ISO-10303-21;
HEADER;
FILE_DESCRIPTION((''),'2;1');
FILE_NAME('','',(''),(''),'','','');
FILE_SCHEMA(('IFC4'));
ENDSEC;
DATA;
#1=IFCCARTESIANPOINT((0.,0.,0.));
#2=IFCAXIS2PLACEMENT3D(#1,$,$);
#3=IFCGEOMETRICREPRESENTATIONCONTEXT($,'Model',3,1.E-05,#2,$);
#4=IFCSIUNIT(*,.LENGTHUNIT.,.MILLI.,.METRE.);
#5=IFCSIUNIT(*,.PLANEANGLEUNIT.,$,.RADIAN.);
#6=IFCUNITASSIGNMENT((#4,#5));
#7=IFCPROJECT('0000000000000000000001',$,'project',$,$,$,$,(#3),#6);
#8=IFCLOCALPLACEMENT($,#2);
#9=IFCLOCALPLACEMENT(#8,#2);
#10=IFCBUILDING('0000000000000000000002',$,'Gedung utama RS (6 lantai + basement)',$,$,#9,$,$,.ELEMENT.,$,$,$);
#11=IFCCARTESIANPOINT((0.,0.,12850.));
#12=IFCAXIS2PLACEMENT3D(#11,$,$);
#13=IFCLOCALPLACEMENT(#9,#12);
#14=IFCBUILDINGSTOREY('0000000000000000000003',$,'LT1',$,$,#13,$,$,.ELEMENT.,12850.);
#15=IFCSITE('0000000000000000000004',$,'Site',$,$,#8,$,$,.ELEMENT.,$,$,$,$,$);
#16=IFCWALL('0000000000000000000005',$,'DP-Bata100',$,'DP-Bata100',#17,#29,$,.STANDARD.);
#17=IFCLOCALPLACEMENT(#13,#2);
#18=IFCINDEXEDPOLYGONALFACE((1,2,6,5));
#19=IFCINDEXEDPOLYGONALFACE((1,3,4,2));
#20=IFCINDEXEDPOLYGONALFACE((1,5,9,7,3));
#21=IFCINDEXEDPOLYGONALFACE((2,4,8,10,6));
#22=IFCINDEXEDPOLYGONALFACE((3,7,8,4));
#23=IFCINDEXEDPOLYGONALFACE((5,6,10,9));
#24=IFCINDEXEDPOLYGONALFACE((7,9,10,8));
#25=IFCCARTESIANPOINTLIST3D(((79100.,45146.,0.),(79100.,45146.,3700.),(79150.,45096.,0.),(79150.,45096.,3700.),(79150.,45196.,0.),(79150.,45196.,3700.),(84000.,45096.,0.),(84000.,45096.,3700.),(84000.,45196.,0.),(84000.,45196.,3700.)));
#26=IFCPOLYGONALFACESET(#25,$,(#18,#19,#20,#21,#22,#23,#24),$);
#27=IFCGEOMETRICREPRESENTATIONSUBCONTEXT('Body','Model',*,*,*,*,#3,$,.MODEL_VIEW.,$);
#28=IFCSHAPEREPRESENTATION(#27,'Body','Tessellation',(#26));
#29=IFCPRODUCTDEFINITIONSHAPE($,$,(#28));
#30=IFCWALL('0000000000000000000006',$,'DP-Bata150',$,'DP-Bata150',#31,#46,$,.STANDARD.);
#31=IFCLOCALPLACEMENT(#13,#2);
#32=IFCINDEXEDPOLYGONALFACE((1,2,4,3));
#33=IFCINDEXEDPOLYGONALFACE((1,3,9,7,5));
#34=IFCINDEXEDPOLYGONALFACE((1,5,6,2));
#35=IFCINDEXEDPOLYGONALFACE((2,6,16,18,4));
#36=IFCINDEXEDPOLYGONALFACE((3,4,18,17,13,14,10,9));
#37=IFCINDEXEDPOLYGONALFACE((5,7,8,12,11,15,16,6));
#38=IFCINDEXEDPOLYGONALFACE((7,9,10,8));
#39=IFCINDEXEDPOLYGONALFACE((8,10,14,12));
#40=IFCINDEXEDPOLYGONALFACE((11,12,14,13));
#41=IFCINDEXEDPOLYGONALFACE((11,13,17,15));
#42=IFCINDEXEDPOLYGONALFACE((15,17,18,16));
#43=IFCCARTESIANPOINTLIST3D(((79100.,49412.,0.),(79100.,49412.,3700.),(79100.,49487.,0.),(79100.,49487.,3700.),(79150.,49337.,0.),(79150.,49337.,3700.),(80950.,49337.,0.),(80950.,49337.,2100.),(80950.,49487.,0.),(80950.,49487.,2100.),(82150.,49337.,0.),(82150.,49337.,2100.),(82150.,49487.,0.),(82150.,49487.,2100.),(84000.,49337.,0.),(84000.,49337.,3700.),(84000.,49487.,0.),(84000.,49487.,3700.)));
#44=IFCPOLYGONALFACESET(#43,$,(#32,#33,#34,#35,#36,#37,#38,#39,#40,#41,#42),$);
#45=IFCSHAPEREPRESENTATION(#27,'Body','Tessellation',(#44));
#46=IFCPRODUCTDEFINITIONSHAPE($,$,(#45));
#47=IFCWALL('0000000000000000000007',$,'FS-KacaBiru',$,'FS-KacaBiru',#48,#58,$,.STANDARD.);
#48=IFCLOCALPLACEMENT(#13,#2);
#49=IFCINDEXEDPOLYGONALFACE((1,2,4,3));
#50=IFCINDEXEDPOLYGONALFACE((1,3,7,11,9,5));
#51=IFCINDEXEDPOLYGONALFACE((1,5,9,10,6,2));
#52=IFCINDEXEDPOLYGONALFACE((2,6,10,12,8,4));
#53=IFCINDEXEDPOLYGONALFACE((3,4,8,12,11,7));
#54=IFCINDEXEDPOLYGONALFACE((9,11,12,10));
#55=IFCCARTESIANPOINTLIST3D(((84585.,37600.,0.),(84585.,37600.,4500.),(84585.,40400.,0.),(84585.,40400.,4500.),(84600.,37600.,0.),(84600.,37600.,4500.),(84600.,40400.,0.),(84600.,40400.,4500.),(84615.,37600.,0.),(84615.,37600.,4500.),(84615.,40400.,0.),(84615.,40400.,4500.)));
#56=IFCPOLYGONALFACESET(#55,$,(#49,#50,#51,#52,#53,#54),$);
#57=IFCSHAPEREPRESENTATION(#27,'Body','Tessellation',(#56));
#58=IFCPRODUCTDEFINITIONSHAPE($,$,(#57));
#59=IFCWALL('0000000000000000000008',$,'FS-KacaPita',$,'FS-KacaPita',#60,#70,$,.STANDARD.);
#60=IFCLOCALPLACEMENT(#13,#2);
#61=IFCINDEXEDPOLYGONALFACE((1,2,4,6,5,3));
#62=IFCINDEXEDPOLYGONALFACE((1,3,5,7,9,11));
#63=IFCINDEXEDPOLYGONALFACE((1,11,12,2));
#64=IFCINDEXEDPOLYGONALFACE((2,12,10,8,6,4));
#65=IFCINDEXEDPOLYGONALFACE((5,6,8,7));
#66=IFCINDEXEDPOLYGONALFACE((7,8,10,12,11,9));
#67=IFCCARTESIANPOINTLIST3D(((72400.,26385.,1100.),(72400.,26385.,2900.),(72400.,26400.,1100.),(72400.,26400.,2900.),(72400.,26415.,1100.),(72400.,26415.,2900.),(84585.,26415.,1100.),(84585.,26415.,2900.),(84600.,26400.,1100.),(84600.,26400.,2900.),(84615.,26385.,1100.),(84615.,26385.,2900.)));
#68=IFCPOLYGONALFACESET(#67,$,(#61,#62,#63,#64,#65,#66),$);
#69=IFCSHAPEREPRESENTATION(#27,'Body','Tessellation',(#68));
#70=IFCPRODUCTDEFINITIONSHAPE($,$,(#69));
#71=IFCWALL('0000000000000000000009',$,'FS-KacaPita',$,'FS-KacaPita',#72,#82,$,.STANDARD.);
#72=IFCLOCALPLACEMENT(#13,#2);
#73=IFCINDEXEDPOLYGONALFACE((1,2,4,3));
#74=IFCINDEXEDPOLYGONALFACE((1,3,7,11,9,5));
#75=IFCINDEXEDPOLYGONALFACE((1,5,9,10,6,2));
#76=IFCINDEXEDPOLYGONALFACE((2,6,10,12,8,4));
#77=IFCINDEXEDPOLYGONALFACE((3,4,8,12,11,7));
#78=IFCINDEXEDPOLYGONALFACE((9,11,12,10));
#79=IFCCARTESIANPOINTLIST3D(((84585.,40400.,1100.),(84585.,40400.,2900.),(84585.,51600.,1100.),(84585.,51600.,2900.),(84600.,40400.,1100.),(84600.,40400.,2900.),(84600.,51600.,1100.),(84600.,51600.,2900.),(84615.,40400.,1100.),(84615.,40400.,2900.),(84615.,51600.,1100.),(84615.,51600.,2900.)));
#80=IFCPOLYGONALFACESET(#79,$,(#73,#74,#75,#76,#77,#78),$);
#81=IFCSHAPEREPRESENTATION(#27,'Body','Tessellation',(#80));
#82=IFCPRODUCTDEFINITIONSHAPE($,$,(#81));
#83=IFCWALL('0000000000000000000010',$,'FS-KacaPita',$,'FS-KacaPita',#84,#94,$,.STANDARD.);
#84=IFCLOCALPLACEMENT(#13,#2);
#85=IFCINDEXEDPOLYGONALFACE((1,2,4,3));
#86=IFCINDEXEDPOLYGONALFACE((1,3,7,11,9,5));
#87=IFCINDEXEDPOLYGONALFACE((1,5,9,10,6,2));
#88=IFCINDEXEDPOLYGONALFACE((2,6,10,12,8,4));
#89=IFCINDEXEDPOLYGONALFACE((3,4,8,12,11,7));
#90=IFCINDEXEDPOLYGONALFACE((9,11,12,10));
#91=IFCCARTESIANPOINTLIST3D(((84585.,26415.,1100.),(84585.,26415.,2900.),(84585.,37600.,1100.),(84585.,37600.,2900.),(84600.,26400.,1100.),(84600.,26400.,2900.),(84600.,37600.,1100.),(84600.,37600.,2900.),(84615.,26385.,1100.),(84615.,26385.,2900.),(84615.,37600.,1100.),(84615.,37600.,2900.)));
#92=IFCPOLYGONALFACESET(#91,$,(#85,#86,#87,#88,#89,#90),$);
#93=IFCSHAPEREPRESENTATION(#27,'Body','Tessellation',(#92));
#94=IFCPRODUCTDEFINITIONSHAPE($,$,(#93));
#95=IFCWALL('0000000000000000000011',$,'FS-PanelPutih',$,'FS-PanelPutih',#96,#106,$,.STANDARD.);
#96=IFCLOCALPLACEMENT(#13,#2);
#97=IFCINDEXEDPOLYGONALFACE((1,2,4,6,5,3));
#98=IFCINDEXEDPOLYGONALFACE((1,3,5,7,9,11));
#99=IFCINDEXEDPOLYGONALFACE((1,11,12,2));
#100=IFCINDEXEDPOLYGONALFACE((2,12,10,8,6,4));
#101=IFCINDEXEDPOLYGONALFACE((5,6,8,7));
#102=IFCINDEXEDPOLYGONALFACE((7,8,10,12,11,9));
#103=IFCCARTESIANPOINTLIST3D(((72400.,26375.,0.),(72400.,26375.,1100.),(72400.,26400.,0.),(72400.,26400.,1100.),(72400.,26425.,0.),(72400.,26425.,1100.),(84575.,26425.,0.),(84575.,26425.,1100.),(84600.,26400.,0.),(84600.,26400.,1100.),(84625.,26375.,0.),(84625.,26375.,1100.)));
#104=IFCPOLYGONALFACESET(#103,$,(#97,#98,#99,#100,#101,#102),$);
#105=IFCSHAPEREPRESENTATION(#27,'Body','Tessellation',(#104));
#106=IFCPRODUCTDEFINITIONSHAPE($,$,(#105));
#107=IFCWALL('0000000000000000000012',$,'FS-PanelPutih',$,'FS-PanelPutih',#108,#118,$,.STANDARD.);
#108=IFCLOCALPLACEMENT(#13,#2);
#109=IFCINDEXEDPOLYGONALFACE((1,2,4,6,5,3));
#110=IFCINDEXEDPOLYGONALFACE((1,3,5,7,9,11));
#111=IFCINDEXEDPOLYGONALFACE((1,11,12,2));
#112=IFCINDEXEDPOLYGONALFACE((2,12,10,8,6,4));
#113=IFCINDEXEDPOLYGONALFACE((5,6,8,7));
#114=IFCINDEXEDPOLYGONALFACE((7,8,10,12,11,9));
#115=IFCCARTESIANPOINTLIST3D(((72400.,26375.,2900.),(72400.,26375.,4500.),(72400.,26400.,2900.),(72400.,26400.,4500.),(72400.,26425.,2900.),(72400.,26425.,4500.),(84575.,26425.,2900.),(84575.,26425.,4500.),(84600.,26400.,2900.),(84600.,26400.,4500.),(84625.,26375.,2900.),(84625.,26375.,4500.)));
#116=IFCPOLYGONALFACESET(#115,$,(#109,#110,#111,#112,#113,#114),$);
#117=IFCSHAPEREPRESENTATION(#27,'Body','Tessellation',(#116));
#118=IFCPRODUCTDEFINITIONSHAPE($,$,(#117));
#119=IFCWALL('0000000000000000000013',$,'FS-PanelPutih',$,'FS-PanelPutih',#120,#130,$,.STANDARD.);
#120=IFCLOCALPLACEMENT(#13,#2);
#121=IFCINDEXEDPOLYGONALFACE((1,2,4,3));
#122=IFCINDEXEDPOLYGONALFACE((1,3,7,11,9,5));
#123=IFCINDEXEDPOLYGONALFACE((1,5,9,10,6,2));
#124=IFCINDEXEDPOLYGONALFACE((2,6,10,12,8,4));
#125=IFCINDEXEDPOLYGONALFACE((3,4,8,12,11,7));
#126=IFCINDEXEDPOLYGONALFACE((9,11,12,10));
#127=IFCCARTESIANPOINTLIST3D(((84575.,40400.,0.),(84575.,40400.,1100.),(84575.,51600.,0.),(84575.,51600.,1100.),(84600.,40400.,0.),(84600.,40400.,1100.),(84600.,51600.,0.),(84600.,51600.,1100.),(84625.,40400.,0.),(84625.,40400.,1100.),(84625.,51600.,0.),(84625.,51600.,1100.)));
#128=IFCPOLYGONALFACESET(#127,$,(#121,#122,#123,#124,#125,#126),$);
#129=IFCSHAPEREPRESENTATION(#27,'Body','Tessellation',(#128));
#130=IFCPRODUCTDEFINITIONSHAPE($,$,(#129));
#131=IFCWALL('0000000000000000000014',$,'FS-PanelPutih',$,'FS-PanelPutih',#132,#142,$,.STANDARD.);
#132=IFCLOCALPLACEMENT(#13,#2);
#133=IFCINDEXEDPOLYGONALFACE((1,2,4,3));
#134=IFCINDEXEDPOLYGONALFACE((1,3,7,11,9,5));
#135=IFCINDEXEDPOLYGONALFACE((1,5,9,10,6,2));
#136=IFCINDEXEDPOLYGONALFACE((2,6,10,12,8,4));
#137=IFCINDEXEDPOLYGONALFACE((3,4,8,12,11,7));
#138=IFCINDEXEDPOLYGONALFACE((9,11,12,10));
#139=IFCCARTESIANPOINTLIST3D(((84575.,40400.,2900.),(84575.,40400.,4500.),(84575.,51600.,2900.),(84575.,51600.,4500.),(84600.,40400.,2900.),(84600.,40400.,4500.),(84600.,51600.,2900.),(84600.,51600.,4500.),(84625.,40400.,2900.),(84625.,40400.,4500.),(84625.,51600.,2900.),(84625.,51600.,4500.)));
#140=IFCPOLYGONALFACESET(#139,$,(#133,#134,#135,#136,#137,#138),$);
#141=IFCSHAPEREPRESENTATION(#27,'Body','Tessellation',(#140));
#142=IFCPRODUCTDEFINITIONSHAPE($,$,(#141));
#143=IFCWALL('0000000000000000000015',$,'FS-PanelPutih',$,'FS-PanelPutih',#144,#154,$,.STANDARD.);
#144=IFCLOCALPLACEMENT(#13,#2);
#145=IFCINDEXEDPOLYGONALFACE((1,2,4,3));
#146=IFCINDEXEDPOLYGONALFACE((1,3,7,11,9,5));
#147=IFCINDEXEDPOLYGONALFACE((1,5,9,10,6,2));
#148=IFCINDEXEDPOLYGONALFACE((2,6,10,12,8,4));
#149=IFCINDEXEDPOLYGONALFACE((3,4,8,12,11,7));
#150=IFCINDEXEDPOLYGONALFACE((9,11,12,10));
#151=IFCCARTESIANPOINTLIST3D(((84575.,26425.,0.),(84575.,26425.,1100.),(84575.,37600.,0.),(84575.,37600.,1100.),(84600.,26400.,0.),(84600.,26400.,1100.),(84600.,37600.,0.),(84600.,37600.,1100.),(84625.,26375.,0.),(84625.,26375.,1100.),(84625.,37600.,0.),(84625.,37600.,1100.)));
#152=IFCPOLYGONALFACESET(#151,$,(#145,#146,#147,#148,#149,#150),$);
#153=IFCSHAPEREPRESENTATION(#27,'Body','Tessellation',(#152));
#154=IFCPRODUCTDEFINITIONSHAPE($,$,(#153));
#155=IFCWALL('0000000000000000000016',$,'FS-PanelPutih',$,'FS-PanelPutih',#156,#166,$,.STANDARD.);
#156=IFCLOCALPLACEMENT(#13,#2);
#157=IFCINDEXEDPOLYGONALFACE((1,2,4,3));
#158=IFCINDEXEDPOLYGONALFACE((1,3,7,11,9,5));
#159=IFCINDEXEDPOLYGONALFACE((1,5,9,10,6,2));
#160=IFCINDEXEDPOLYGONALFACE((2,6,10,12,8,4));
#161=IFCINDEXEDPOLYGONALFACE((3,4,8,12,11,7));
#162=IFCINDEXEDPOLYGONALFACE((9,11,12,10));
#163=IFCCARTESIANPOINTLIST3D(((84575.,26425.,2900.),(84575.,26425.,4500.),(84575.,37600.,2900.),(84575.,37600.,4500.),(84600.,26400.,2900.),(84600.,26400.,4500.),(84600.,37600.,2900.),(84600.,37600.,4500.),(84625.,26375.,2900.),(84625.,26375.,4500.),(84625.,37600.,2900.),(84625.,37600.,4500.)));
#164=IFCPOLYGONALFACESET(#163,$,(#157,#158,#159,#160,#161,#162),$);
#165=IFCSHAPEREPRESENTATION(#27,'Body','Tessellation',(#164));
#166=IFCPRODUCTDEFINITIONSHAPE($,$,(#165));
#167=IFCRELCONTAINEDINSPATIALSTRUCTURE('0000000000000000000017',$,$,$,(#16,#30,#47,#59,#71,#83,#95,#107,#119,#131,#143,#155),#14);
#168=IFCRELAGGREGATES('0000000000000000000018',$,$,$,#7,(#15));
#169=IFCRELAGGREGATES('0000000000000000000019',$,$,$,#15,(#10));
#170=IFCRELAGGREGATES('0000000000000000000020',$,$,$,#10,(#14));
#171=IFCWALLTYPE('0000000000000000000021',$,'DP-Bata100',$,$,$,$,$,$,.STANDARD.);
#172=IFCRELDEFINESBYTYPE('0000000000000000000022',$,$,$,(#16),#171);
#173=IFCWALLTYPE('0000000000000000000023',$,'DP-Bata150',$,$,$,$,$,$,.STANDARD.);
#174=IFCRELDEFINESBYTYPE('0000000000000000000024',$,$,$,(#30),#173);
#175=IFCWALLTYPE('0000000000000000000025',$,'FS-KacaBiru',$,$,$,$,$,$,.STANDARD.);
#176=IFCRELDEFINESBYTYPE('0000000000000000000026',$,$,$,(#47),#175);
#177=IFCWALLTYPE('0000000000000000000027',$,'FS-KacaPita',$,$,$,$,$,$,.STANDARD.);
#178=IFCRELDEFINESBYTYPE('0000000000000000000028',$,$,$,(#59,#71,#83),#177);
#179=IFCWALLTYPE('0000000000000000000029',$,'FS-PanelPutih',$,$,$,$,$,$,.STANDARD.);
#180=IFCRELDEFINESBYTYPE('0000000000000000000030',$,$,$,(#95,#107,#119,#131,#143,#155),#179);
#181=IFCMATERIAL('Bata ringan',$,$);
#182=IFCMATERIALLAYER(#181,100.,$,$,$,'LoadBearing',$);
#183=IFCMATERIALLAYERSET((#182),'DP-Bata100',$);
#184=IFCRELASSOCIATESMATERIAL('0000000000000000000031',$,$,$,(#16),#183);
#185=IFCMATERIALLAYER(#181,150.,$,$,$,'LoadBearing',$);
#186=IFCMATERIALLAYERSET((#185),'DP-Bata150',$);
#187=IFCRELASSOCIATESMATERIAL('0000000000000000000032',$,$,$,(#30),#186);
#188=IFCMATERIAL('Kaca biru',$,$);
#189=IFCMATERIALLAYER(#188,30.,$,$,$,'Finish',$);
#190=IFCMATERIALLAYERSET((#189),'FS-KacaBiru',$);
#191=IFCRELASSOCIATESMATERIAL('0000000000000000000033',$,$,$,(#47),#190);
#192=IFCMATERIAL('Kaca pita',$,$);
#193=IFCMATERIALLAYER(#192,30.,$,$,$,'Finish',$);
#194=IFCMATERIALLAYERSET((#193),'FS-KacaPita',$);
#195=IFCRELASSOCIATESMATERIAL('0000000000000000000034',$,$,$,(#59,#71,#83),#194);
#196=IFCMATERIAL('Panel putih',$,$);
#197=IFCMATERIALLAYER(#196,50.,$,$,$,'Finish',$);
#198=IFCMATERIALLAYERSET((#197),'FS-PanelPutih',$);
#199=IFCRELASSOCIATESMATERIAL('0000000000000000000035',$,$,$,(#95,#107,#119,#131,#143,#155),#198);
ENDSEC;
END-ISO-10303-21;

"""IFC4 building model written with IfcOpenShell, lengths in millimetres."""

from ifc_helpers import new_model, si_unit, frame, frame_2d, origin, place, context, subcontext, project, spatial, polyline, rectangle, outline, extrude, material, layer, layer_set, layer_usage, type_object, element, save


model = new_model("IFC4")

# Units and contexts
model_context = context("Model", 3, precision=1e-05, world=origin())
body_context = subcontext(model_context, "Body", "Model", "MODEL_VIEW")
ifc_project = project(units=[si_unit("LENGTHUNIT", "METRE", prefix="MILLI"), si_unit("PLANEANGLEUNIT", "RADIAN")], contexts=[model_context])

# Site, building, storey
site_placement = place(None, origin())
site = spatial("IfcSite", under=ifc_project, at=site_placement, Name="Site", CompositionType="ELEMENT")
building_placement = place(site_placement, origin())
building = spatial("IfcBuilding", under=site, at=building_placement, Name="Gedung utama RS (6 lantai + basement)", CompositionType="ELEMENT")
storey_placement = place(building_placement, frame((0.0, 0.0, 12850.0)))
storey = spatial("IfcBuildingStorey", under=building, at=storey_placement, Name="LT1", CompositionType="ELEMENT", Elevation=12850.0)

# Wall
ifc_material_1 = material(Name="Bata ringan")
ifc_layer_1 = layer(ifc_material_1, 100.0, Category="LoadBearing")
ifc_layer_set_1 = layer_set([ifc_layer_1], Name="DP-Bata100")
ifc_layer_usage_1 = layer_usage(ifc_layer_set_1, "AXIS2", "NEGATIVE", 50.0)
wall_type_1 = type_object("IfcWallType", Name="DP-Bata100", PredefinedType="STANDARD")
wall_1_placement = place(storey_placement, frame((84000.0, 45146.0, 0.0), z_axis=(0.0, 0.0, 1.0), x_axis=(-1.0, 0.0, 0.0)))
element("IfcWall", 1, at=wall_1_placement, inside=storey, type_object=wall_type_1, material=ifc_layer_usage_1, Name="DP-Bata100", ObjectType="DP-Bata100", PredefinedType="STANDARD", context=body_context, shape_type="SweptSolid", body=[
    extrude(outline(polyline([(0.0, -50.0), (0.0, 50.0), (4850.0, 50.0), (4900.0, 0.0), (4850.0, -50.0), (0.0, -50.0)])), origin(), (0.0, 0.0, 1.0), 3700.0),
])

# Wall, opening
ifc_layer_2 = layer(ifc_material_1, 150.0, Category="LoadBearing")
ifc_layer_set_2 = layer_set([ifc_layer_2], Name="DP-Bata150")
ifc_layer_usage_2 = layer_usage(ifc_layer_set_2, "AXIS2", "NEGATIVE", 75.0)
wall_type_2 = type_object("IfcWallType", Name="DP-Bata150", PredefinedType="STANDARD")
wall_2_placement = place(storey_placement, frame((84000.0, 49412.0, 0.0), z_axis=(0.0, 0.0, 1.0), x_axis=(-1.0, 0.0, 0.0)))
wall_2 = element("IfcWall", 2, at=wall_2_placement, inside=storey, type_object=wall_type_2, material=ifc_layer_usage_2, Name="DP-Bata150", ObjectType="DP-Bata150", PredefinedType="STANDARD", context=body_context, shape_type="SweptSolid", body=[
    extrude(outline(polyline([(0.0, -75.0), (0.0, 75.0), (4850.0, 75.0), (4900.0, 0.0), (4900.0, -75.0), (0.0, -75.0)])), origin(), (0.0, 0.0, 1.0), 3700.0),
])
opening_placement = place(wall_2_placement, frame((1850.0, 0.0, 0.0), z_axis=(0.0, 0.0, 1.0), x_axis=(1.0, 0.0, 0.0)))
element("IfcOpeningElement", 3, at=opening_placement, cuts=wall_2, PredefinedType="OPENING", context=body_context, shape_type="SweptSolid", body=[
    extrude(rectangle(XDim=1200.0, YDim=170.0, at=frame_2d((600.0, 0.0))), origin(), (0.0, 0.0, 1.0), 2100.0),
])

# Walls
ifc_material_2 = material(Name="Kaca biru")
ifc_layer_3 = layer(ifc_material_2, 30.0, Category="Finish")
ifc_layer_set_3 = layer_set([ifc_layer_3], Name="FS-KacaBiru")
ifc_layer_usage_3 = layer_usage(ifc_layer_set_3, "AXIS2", "NEGATIVE", 15.0)
wall_type_3 = type_object("IfcWallType", Name="FS-KacaBiru", PredefinedType="STANDARD")
wall_3_placement = place(storey_placement, frame((84600.0, 40400.0, 0.0), z_axis=(0.0, 0.0, 1.0), x_axis=(0.0, -1.0, 0.0)))
element("IfcWall", 4, at=wall_3_placement, inside=storey, type_object=wall_type_3, material=ifc_layer_usage_3, Name="FS-KacaBiru", ObjectType="FS-KacaBiru", PredefinedType="STANDARD", context=body_context, shape_type="SweptSolid", body=[
    extrude(outline(polyline([(0.0, -15.0), (0.0, 0.0), (0.0, 15.0), (2800.0, 15.0), (2800.0, 0.0), (2800.0, -15.0), (0.0, -15.0)])), origin(), (0.0, 0.0, 1.0), 4500.0),
])
ifc_material_3 = material(Name="Kaca pita")
ifc_layer_4 = layer(ifc_material_3, 30.0, Category="Finish")
ifc_layer_set_4 = layer_set([ifc_layer_4], Name="FS-KacaPita")
ifc_layer_usage_4 = layer_usage(ifc_layer_set_4, "AXIS2", "NEGATIVE", 15.0)
wall_type_4 = type_object("IfcWallType", Name="FS-KacaPita", PredefinedType="STANDARD")
wall_4_placement = place(storey_placement, frame((84600.0, 26400.0, 1100.0), z_axis=(0.0, 0.0, 1.0), x_axis=(-1.0, 0.0, 0.0)))
element("IfcWall", 5, at=wall_4_placement, inside=storey, type_object=wall_type_4, material=ifc_layer_usage_4, Name="FS-KacaPita", ObjectType="FS-KacaPita", PredefinedType="STANDARD", context=body_context, shape_type="SweptSolid", body=[
    extrude(outline(polyline([(15.0, -15.0), (0.0, 0.0), (-15.0, 15.0), (12200.0, 15.0), (12200.0, 0.0), (12200.0, -15.0), (15.0, -15.0)])), origin(), (0.0, 0.0, 1.0), 1800.0),
])
wall_5_placement = place(storey_placement, frame((84600.0, 51600.0, 1100.0), z_axis=(0.0, 0.0, 1.0), x_axis=(0.0, -1.0, 0.0)))
element("IfcWall", 6, at=wall_5_placement, inside=storey, type_object=wall_type_4, material=ifc_layer_usage_4, Name="FS-KacaPita", ObjectType="FS-KacaPita", PredefinedType="STANDARD", context=body_context, shape_type="SweptSolid", body=[
    extrude(outline(polyline([(0.0, -15.0), (0.0, 0.0), (0.0, 15.0), (11200.0, 15.0), (11200.0, 0.0), (11200.0, -15.0), (0.0, -15.0)])), origin(), (0.0, 0.0, 1.0), 1800.0),
])
wall_6_placement = place(storey_placement, frame((84600.0, 37600.0, 1100.0), z_axis=(0.0, 0.0, 1.0), x_axis=(0.0, -1.0, 0.0)))
element("IfcWall", 7, at=wall_6_placement, inside=storey, type_object=wall_type_4, material=ifc_layer_usage_4, Name="FS-KacaPita", ObjectType="FS-KacaPita", PredefinedType="STANDARD", context=body_context, shape_type="SweptSolid", body=[
    extrude(outline(polyline([(0.0, -15.0), (0.0, 0.0), (0.0, 15.0), (11215.0, 15.0), (11200.0, 0.0), (11185.0, -15.0), (0.0, -15.0)])), origin(), (0.0, 0.0, 1.0), 1800.0),
])
ifc_material_4 = material(Name="Panel putih")
ifc_layer_5 = layer(ifc_material_4, 50.0, Category="Finish")
ifc_layer_set_5 = layer_set([ifc_layer_5], Name="FS-PanelPutih")
ifc_layer_usage_5 = layer_usage(ifc_layer_set_5, "AXIS2", "NEGATIVE", 25.0)
wall_type_5 = type_object("IfcWallType", Name="FS-PanelPutih", PredefinedType="STANDARD")
wall_7_placement = place(storey_placement, frame((84600.0, 26400.0, 0.0), z_axis=(0.0, 0.0, 1.0), x_axis=(-1.0, 0.0, 0.0)))
element("IfcWall", 8, at=wall_7_placement, inside=storey, type_object=wall_type_5, material=ifc_layer_usage_5, Name="FS-PanelPutih", ObjectType="FS-PanelPutih", PredefinedType="STANDARD", context=body_context, shape_type="SweptSolid", body=[
    extrude(outline(polyline([(25.0, -25.0), (0.0, 0.0), (-25.0, 25.0), (12200.0, 25.0), (12200.0, 0.0), (12200.0, -25.0), (25.0, -25.0)])), origin(), (0.0, 0.0, 1.0), 1100.0),
])
wall_8_placement = place(storey_placement, frame((84600.0, 26400.0, 2900.0), z_axis=(0.0, 0.0, 1.0), x_axis=(-1.0, 0.0, 0.0)))
element("IfcWall", 9, at=wall_8_placement, inside=storey, type_object=wall_type_5, material=ifc_layer_usage_5, Name="FS-PanelPutih", ObjectType="FS-PanelPutih", PredefinedType="STANDARD", context=body_context, shape_type="SweptSolid", body=[
    extrude(outline(polyline([(25.0, -25.0), (0.0, 0.0), (-25.0, 25.0), (12200.0, 25.0), (12200.0, 0.0), (12200.0, -25.0), (25.0, -25.0)])), origin(), (0.0, 0.0, 1.0), 1600.0),
])
wall_9_placement = place(storey_placement, frame((84600.0, 51600.0, 0.0), z_axis=(0.0, 0.0, 1.0), x_axis=(0.0, -1.0, 0.0)))
element("IfcWall", 10, at=wall_9_placement, inside=storey, type_object=wall_type_5, material=ifc_layer_usage_5, Name="FS-PanelPutih", ObjectType="FS-PanelPutih", PredefinedType="STANDARD", context=body_context, shape_type="SweptSolid", body=[
    extrude(outline(polyline([(0.0, -25.0), (0.0, 0.0), (0.0, 25.0), (11200.0, 25.0), (11200.0, 0.0), (11200.0, -25.0), (0.0, -25.0)])), origin(), (0.0, 0.0, 1.0), 1100.0),
])
wall_10_placement = place(storey_placement, frame((84600.0, 51600.0, 2900.0), z_axis=(0.0, 0.0, 1.0), x_axis=(0.0, -1.0, 0.0)))
element("IfcWall", 11, at=wall_10_placement, inside=storey, type_object=wall_type_5, material=ifc_layer_usage_5, Name="FS-PanelPutih", ObjectType="FS-PanelPutih", PredefinedType="STANDARD", context=body_context, shape_type="SweptSolid", body=[
    extrude(outline(polyline([(0.0, -25.0), (0.0, 0.0), (0.0, 25.0), (11200.0, 25.0), (11200.0, 0.0), (11200.0, -25.0), (0.0, -25.0)])), origin(), (0.0, 0.0, 1.0), 1600.0),
])
wall_11_placement = place(storey_placement, frame((84600.0, 37600.0, 0.0), z_axis=(0.0, 0.0, 1.0), x_axis=(0.0, -1.0, 0.0)))
element("IfcWall", 12, at=wall_11_placement, inside=storey, type_object=wall_type_5, material=ifc_layer_usage_5, Name="FS-PanelPutih", ObjectType="FS-PanelPutih", PredefinedType="STANDARD", context=body_context, shape_type="SweptSolid", body=[
    extrude(outline(polyline([(0.0, -25.0), (0.0, 0.0), (0.0, 25.0), (11225.0, 25.0), (11200.0, 0.0), (11175.0, -25.0), (0.0, -25.0)])), origin(), (0.0, 0.0, 1.0), 1100.0),
])
wall_12_placement = place(storey_placement, frame((84600.0, 37600.0, 2900.0), z_axis=(0.0, 0.0, 1.0), x_axis=(0.0, -1.0, 0.0)))
element("IfcWall", 13, at=wall_12_placement, inside=storey, type_object=wall_type_5, material=ifc_layer_usage_5, Name="FS-PanelPutih", ObjectType="FS-PanelPutih", PredefinedType="STANDARD", context=body_context, shape_type="SweptSolid", body=[
    extrude(outline(polyline([(0.0, -25.0), (0.0, 0.0), (0.0, 25.0), (11225.0, 25.0), (11200.0, 0.0), (11175.0, -25.0), (0.0, -25.0)])), origin(), (0.0, 0.0, 1.0), 1600.0),
])

save(model, "model.ifc")
